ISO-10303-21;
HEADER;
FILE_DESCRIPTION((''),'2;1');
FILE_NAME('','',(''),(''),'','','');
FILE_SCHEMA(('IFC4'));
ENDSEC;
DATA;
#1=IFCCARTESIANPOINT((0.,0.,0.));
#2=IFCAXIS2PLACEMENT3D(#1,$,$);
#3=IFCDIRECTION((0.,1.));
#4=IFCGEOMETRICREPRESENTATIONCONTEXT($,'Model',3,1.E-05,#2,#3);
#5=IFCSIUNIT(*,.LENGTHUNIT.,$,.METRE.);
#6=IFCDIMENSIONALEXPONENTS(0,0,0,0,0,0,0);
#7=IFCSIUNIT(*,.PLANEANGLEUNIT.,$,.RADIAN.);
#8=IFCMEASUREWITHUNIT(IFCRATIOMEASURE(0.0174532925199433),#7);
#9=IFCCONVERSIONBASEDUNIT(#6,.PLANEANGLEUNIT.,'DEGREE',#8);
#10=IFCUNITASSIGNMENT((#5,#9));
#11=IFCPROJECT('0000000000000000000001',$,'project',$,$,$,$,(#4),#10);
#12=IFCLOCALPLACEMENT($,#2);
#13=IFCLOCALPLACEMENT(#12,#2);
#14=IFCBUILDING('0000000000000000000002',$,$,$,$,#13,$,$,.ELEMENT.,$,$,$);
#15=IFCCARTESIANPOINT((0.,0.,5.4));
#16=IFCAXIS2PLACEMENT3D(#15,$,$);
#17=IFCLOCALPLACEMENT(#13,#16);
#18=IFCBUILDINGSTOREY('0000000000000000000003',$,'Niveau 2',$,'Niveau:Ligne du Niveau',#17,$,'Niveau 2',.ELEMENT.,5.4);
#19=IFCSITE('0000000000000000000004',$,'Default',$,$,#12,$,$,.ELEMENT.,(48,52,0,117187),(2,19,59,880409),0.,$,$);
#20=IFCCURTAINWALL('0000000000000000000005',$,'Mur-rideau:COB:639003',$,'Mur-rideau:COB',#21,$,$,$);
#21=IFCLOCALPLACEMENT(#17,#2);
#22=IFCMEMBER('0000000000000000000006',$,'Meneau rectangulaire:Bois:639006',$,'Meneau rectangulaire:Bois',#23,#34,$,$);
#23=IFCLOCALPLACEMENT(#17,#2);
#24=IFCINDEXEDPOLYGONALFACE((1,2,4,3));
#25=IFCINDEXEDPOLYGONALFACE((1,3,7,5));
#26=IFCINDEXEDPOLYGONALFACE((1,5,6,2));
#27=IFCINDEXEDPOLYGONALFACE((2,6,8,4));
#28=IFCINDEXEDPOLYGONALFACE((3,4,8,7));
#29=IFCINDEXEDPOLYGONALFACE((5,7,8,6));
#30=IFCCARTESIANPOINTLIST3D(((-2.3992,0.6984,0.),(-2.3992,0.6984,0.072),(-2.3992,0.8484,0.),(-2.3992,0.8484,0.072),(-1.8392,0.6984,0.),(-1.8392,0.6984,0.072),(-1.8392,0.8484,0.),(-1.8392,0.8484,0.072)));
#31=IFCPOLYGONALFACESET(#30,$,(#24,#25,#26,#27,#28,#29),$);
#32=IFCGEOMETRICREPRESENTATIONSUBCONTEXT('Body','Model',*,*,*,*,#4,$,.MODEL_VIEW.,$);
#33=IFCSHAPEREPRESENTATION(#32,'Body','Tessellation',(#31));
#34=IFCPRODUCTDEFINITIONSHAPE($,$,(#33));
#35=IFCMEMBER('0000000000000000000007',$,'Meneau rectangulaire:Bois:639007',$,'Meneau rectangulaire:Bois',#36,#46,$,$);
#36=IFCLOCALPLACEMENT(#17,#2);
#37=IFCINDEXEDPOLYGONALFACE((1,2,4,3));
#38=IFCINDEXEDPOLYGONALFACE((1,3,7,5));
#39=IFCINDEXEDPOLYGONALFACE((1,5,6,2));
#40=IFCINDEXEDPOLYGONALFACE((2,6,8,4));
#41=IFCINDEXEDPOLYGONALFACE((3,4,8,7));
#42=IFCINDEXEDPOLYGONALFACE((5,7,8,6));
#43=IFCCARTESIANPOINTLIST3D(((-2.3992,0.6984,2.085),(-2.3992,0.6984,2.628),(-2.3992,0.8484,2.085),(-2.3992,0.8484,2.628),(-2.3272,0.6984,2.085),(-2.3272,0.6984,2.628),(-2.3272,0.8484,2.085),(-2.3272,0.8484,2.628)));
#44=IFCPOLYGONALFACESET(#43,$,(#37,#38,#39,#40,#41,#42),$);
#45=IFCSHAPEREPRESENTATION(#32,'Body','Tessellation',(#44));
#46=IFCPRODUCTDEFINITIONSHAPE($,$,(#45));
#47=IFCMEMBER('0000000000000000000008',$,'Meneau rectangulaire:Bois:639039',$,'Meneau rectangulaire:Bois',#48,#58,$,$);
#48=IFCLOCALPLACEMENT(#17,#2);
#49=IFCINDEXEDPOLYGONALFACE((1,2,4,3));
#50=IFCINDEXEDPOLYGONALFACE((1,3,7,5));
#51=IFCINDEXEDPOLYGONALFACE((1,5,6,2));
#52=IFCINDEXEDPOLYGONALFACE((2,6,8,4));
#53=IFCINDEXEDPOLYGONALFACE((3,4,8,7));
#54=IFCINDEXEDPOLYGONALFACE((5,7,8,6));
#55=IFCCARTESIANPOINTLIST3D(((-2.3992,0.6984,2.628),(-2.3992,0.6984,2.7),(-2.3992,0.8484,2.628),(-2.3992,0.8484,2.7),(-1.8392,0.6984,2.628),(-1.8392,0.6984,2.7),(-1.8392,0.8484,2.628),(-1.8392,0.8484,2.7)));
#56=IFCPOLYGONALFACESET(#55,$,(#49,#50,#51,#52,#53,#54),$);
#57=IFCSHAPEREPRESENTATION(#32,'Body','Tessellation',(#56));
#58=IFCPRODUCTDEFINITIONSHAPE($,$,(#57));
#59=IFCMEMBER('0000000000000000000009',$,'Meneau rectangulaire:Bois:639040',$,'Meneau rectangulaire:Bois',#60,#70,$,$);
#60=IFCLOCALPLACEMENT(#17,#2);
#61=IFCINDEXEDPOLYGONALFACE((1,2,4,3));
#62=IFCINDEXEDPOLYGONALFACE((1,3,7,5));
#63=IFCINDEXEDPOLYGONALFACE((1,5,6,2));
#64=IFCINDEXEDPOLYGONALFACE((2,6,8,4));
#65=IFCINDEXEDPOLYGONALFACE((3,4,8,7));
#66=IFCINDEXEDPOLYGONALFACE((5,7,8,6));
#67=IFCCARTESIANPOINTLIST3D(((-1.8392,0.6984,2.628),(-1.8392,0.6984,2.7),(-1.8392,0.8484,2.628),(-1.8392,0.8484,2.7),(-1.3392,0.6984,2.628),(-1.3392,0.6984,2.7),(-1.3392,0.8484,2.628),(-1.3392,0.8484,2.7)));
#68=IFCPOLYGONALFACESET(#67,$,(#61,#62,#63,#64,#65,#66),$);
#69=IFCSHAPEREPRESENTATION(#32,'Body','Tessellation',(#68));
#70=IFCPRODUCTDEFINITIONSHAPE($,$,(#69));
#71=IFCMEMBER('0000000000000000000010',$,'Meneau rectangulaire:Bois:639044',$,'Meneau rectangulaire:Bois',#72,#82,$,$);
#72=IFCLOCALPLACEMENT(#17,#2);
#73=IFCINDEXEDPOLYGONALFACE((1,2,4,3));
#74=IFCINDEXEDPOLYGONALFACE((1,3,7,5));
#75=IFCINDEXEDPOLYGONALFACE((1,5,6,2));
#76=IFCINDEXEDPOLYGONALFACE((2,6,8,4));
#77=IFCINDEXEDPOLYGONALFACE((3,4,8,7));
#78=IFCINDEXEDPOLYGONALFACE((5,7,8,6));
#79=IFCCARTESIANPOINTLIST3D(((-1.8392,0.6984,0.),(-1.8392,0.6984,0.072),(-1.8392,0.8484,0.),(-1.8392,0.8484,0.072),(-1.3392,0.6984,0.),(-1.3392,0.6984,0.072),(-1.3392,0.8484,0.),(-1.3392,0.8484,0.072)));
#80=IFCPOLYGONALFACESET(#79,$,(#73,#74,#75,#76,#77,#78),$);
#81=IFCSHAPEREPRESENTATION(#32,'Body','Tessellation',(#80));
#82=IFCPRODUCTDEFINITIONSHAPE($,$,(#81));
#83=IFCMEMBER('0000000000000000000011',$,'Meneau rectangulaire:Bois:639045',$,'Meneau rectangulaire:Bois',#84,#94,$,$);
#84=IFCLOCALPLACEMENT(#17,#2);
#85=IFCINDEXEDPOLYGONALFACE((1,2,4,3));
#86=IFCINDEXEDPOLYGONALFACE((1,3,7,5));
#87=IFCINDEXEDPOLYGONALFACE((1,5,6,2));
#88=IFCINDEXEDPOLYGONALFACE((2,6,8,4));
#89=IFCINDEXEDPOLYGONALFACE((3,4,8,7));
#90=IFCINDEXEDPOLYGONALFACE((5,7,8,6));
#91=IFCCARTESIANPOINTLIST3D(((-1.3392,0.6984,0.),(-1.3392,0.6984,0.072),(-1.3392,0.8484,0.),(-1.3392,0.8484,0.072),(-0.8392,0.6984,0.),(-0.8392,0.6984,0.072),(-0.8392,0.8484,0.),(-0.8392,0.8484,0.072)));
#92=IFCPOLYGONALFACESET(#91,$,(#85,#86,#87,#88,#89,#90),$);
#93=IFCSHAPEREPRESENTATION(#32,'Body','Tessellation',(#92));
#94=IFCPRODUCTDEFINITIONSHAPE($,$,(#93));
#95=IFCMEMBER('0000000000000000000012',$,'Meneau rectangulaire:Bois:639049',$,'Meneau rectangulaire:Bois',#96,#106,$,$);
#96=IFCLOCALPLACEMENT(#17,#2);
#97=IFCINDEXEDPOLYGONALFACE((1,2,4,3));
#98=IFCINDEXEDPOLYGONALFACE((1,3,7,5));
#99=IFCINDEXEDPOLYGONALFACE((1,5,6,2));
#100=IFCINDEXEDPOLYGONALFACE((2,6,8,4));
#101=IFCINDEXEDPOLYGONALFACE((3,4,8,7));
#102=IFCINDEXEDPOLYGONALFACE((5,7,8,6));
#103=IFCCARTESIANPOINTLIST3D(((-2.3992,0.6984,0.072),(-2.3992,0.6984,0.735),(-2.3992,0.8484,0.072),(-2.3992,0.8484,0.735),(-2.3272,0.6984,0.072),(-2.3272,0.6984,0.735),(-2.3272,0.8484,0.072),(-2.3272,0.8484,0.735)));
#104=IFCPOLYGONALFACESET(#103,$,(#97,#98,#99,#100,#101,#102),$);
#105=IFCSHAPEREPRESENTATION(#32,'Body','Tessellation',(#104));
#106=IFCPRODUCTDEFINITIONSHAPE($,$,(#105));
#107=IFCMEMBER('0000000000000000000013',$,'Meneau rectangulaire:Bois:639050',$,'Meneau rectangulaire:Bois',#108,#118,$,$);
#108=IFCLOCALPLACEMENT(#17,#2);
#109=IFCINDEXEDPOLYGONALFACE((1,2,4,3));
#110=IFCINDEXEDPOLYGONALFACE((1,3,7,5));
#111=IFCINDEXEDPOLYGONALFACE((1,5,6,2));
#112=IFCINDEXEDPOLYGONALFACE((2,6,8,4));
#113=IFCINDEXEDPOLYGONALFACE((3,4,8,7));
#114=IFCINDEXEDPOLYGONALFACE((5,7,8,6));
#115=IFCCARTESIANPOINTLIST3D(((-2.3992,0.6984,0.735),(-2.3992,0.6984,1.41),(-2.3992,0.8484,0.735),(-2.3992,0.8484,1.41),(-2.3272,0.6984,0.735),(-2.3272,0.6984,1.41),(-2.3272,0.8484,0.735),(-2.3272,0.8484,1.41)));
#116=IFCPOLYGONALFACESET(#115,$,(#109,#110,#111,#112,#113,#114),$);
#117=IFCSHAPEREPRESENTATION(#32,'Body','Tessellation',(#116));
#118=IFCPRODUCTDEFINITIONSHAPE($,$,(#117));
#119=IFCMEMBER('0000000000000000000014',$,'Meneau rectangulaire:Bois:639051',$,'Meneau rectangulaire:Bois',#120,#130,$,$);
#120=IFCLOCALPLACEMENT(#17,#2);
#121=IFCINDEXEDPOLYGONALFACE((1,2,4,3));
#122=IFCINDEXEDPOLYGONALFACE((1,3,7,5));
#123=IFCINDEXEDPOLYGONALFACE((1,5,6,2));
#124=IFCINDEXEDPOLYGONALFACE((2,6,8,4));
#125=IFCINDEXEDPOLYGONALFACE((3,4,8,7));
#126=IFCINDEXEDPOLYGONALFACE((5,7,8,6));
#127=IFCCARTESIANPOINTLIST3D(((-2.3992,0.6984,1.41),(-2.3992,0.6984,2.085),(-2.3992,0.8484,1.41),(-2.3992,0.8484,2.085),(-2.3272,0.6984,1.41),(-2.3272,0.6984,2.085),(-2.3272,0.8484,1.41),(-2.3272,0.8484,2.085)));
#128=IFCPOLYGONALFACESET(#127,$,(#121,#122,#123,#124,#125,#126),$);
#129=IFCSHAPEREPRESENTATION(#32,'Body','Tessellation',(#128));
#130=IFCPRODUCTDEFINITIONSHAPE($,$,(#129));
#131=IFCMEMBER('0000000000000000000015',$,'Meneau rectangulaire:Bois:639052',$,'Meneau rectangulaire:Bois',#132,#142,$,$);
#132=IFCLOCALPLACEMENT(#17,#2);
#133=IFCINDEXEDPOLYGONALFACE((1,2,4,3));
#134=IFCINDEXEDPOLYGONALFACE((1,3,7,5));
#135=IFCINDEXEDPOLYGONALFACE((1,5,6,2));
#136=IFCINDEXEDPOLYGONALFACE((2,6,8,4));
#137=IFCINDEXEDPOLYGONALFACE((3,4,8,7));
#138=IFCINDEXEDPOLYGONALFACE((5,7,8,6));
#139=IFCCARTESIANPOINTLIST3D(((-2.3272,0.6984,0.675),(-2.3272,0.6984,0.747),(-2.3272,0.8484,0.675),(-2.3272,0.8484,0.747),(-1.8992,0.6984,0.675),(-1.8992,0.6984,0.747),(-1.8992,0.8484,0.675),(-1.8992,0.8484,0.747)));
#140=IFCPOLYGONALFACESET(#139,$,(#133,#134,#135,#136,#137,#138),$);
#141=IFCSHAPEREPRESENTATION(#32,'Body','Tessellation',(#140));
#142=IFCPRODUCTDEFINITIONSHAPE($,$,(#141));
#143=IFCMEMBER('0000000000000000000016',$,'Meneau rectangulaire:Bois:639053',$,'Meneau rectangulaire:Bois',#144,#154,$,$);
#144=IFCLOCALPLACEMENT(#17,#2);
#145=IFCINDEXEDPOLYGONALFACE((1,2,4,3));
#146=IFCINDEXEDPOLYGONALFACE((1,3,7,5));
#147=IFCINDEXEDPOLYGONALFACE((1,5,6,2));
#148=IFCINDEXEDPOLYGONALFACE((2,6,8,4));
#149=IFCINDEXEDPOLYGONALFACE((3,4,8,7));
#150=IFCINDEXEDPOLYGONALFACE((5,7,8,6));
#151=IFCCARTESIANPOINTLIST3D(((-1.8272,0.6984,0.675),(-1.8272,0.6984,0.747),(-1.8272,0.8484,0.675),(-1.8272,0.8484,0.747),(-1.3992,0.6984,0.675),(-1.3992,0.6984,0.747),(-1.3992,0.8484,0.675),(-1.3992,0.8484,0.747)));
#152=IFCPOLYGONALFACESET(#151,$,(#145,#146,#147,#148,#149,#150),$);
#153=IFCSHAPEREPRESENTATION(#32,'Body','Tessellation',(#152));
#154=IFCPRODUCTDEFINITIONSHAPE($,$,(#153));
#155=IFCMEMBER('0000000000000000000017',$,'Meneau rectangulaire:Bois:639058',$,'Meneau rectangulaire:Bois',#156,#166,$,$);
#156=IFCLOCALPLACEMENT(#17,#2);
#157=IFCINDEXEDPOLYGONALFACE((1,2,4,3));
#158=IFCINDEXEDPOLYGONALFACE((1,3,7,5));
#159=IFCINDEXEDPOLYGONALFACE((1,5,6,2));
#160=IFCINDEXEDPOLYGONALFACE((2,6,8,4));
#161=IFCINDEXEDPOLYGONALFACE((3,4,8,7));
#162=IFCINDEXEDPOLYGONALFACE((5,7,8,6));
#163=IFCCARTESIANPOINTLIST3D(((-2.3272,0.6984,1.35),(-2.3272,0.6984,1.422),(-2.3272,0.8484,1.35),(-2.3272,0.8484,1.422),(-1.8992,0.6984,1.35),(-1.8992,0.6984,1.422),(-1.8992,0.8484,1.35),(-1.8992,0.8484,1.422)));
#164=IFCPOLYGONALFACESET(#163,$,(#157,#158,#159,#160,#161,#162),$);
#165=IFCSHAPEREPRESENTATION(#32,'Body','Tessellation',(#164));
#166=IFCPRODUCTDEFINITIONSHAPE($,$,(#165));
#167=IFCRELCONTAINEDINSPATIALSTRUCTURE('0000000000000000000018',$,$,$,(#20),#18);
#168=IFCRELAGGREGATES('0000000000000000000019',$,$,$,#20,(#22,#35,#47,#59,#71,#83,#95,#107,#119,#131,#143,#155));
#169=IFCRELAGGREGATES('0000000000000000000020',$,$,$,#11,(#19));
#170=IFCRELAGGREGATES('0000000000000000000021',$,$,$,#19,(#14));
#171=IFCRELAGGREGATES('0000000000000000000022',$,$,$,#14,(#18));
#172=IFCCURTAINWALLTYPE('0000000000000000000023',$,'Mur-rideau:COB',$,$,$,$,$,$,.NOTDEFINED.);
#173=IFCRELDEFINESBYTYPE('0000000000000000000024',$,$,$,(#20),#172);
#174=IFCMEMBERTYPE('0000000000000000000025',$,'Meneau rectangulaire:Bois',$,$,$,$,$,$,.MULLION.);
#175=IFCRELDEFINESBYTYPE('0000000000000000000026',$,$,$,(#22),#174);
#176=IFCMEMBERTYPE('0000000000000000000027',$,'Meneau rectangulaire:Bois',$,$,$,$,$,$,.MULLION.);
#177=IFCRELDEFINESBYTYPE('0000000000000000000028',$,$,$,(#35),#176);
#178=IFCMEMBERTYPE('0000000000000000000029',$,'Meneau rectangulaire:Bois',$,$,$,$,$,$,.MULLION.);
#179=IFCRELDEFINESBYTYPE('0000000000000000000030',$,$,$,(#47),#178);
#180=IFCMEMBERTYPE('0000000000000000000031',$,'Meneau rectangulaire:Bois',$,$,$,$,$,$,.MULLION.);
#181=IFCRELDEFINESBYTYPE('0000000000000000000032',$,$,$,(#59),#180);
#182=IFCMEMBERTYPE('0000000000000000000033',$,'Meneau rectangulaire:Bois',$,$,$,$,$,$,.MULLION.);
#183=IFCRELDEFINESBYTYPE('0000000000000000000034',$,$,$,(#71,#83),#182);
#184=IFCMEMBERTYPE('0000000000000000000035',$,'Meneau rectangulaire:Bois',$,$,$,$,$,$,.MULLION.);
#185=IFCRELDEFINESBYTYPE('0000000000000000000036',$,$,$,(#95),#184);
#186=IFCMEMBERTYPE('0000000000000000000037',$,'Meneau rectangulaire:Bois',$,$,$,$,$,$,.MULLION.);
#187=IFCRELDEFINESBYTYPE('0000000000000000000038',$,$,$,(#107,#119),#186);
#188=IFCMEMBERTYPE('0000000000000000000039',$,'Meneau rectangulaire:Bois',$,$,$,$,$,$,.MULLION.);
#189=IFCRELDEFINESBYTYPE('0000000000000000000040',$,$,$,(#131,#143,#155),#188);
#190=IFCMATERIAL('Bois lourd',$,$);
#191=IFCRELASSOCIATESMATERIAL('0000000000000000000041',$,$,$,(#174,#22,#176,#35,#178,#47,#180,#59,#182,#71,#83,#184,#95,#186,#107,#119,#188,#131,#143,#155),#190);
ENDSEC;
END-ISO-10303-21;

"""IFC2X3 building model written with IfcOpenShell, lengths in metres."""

from ifc_helpers import new_model, entity, si_unit, converted_unit, direction, frame, origin, origin_2d_with_axis, place, context, subcontext, project, spatial, rectangle, extrude, source, transform, mapped, material, type_object, type_shapes, element, aggregate, save


model = new_model("IFC2X3")

# Units and contexts
model_context = context("Model", 3, precision=1e-05, world=origin(), true_north=direction((0.0, 1.0)))
body_context = subcontext(model_context, "Body", "Model", "MODEL_VIEW")
ifc_project = project(units=[si_unit("LENGTHUNIT", "METRE"), converted_unit("PLANEANGLEUNIT", "DEGREE", entity("IfcRatioMeasure", 0.0174532925199433), si_unit("PLANEANGLEUNIT", "RADIAN"), dimensions=[0, 0, 0, 0, 0, 0, 0])], contexts=[model_context])

# Site, building, storey
site_placement = place(None, origin())
site = spatial("IfcSite", under=ifc_project, at=site_placement, Name="Default", CompositionType="ELEMENT", RefLatitude=(48, 52, 0, 117187), RefLongitude=(2, 19, 59, 880409), RefElevation=0.0)
building_placement = place(site_placement, origin())
building = spatial("IfcBuilding", under=site, at=building_placement, CompositionType="ELEMENT")
storey_placement = place(building_placement, frame((0.0, 0.0, 5.4)))
storey = spatial("IfcBuildingStorey", under=building, at=storey_placement, Name="Niveau 2", ObjectType="Niveau:Ligne du Niveau", LongName="Niveau 2", CompositionType="ELEMENT", Elevation=5.4)

# Curtain wall, members
curtain_wall_type_1 = type_object("IfcCurtainWallType", Name="Mur-rideau:COB", PredefinedType="NOTDEFINED")
curtain_wall_1_placement = place(storey_placement, frame((0.0, 0.0, -5.4)))
curtain_wall_1 = element("IfcCurtainWall", 1, at=curtain_wall_1_placement, inside=storey, type_object=curtain_wall_type_1, Name="Mur-rideau:COB:639003", ObjectType="Mur-rideau:COB")
ifc_material_1 = material(Name="Bois lourd")
member_type_1 = type_object("IfcMemberType", Name="Meneau rectangulaire:Bois", PredefinedType="MULLION", material=ifc_material_1)
shared_shape_1 = source(origin(), body_context, "Body", "SweptSolid", [
    extrude(rectangle(XDim=0.15, YDim=0.072, at=origin_2d_with_axis()), frame((-0.036, 0.0, -0.56), z_axis=(0.0, 0.0, 1.0), x_axis=(0.0, -1.0, 0.0)), (0.0, 0.0, 1.0), 0.56),
])
type_shapes(member_type_1, [shared_shape_1])
member_1_placement = place(storey_placement, frame((-2.3992, 0.7734, 0.0), z_axis=(-1.0, 0.0, 0.0), x_axis=(0.0, 0.0, -1.0)))
member_1 = element("IfcMember", 2, at=member_1_placement, type_object=member_type_1, material=ifc_material_1, Name="Meneau rectangulaire:Bois:639006", ObjectType="Meneau rectangulaire:Bois", context=body_context, shape_type="MappedRepresentation", body=[
    mapped(shared_shape_1, transform((0.0, 0.0, 0.0), scale=1.0)),
])
member_type_2 = type_object("IfcMemberType", Name="Meneau rectangulaire:Bois", PredefinedType="MULLION", material=ifc_material_1)
shared_shape_2 = source(origin(), body_context, "Body", "SweptSolid", [
    extrude(rectangle(XDim=0.15, YDim=0.072, at=origin_2d_with_axis()), frame((-0.036, 0.0, -0.543), z_axis=(0.0, 0.0, 1.0), x_axis=(0.0, -1.0, 0.0)), (0.0, 0.0, 1.0), 0.543),
])
type_shapes(member_type_2, [shared_shape_2])
member_2_placement = place(storey_placement, frame((-2.3992, 0.7734, 2.628), z_axis=(0.0, 0.0, 1.0), x_axis=(-1.0, 0.0, 0.0)))
member_2 = element("IfcMember", 3, at=member_2_placement, type_object=member_type_2, material=ifc_material_1, Name="Meneau rectangulaire:Bois:639007", ObjectType="Meneau rectangulaire:Bois", context=body_context, shape_type="MappedRepresentation", body=[
    mapped(shared_shape_2, transform((0.0, 0.0, 0.0), scale=1.0)),
])
member_type_3 = type_object("IfcMemberType", Name="Meneau rectangulaire:Bois", PredefinedType="MULLION", material=ifc_material_1)
shared_shape_3 = source(origin(), body_context, "Body", "SweptSolid", [
    extrude(rectangle(XDim=0.15, YDim=0.072, at=origin_2d_with_axis()), frame((-0.036, 0.0, -0.56), z_axis=(0.0, 0.0, 1.0), x_axis=(0.0, -1.0, 0.0)), (0.0, 0.0, 1.0), 0.56),
])
type_shapes(member_type_3, [shared_shape_3])
member_3_placement = place(storey_placement, frame((-1.8392, 0.7734, 2.7), z_axis=(1.0, 0.0, 0.0), x_axis=(0.0, 0.0, 1.0)))
member_3 = element("IfcMember", 4, at=member_3_placement, type_object=member_type_3, material=ifc_material_1, Name="Meneau rectangulaire:Bois:639039", ObjectType="Meneau rectangulaire:Bois", context=body_context, shape_type="MappedRepresentation", body=[
    mapped(shared_shape_3, transform((0.0, 0.0, 0.0), scale=1.0)),
])
member_type_4 = type_object("IfcMemberType", Name="Meneau rectangulaire:Bois", PredefinedType="MULLION", material=ifc_material_1)
shared_shape_4 = source(origin(), body_context, "Body", "SweptSolid", [
    extrude(rectangle(XDim=0.15, YDim=0.072, at=origin_2d_with_axis()), frame((-0.036, 0.0, -0.5), z_axis=(0.0, 0.0, 1.0), x_axis=(0.0, -1.0, 0.0)), (0.0, 0.0, 1.0), 0.5),
])
type_shapes(member_type_4, [shared_shape_4])
member_4_placement = place(storey_placement, frame((-1.3392, 0.7734, 2.7), z_axis=(1.0, 0.0, 0.0), x_axis=(0.0, 0.0, 1.0)))
member_4 = element("IfcMember", 5, at=member_4_placement, type_object=member_type_4, material=ifc_material_1, Name="Meneau rectangulaire:Bois:639040", ObjectType="Meneau rectangulaire:Bois", context=body_context, shape_type="MappedRepresentation", body=[
    mapped(shared_shape_4, transform((0.0, 0.0, 0.0), scale=1.0)),
])
member_type_5 = type_object("IfcMemberType", Name="Meneau rectangulaire:Bois", PredefinedType="MULLION", material=ifc_material_1)
shared_shape_5 = source(origin(), body_context, "Body", "SweptSolid", [
    extrude(rectangle(XDim=0.15, YDim=0.072, at=origin_2d_with_axis()), frame((-0.036, 0.0, -0.5), z_axis=(0.0, 0.0, 1.0), x_axis=(0.0, -1.0, 0.0)), (0.0, 0.0, 1.0), 0.5),
])
type_shapes(member_type_5, [shared_shape_5])
member_5_placement = place(storey_placement, frame((-1.8392, 0.7734, 0.0), z_axis=(-1.0, 0.0, 0.0), x_axis=(0.0, 0.0, -1.0)))
member_5 = element("IfcMember", 6, at=member_5_placement, type_object=member_type_5, material=ifc_material_1, Name="Meneau rectangulaire:Bois:639044", ObjectType="Meneau rectangulaire:Bois", context=body_context, shape_type="MappedRepresentation", body=[
    mapped(shared_shape_5, transform((0.0, 0.0, 0.0), scale=1.0)),
])
member_6_placement = place(storey_placement, frame((-1.3392, 0.7734, 0.0), z_axis=(-1.0, 0.0, 0.0), x_axis=(0.0, 0.0, -1.0)))
member_6 = element("IfcMember", 7, at=member_6_placement, type_object=member_type_5, material=ifc_material_1, Name="Meneau rectangulaire:Bois:639045", ObjectType="Meneau rectangulaire:Bois", context=body_context, shape_type="MappedRepresentation", body=[
    mapped(shared_shape_5, transform((0.0, 0.0, 0.0), scale=1.0)),
])
member_type_6 = type_object("IfcMemberType", Name="Meneau rectangulaire:Bois", PredefinedType="MULLION", material=ifc_material_1)
shared_shape_6 = source(origin(), body_context, "Body", "SweptSolid", [
    extrude(rectangle(XDim=0.15, YDim=0.072, at=origin_2d_with_axis()), frame((-0.036, 0.0, -0.663), z_axis=(0.0, 0.0, 1.0), x_axis=(0.0, -1.0, 0.0)), (0.0, 0.0, 1.0), 0.663),
])
type_shapes(member_type_6, [shared_shape_6])
member_7_placement = place(storey_placement, frame((-2.3992, 0.7734, 0.735), z_axis=(0.0, 0.0, 1.0), x_axis=(-1.0, 0.0, 0.0)))
member_7 = element("IfcMember", 8, at=member_7_placement, type_object=member_type_6, material=ifc_material_1, Name="Meneau rectangulaire:Bois:639049", ObjectType="Meneau rectangulaire:Bois", context=body_context, shape_type="MappedRepresentation", body=[
    mapped(shared_shape_6, transform((0.0, 0.0, 0.0), scale=1.0)),
])
member_type_7 = type_object("IfcMemberType", Name="Meneau rectangulaire:Bois", PredefinedType="MULLION", material=ifc_material_1)
shared_shape_7 = source(origin(), body_context, "Body", "SweptSolid", [
    extrude(rectangle(XDim=0.15, YDim=0.072, at=origin_2d_with_axis()), frame((-0.036, 0.0, -0.675), z_axis=(0.0, 0.0, 1.0), x_axis=(0.0, -1.0, 0.0)), (0.0, 0.0, 1.0), 0.675),
])
type_shapes(member_type_7, [shared_shape_7])
member_8_placement = place(storey_placement, frame((-2.3992, 0.7734, 1.41), z_axis=(0.0, 0.0, 1.0), x_axis=(-1.0, 0.0, 0.0)))
member_8 = element("IfcMember", 9, at=member_8_placement, type_object=member_type_7, material=ifc_material_1, Name="Meneau rectangulaire:Bois:639050", ObjectType="Meneau rectangulaire:Bois", context=body_context, shape_type="MappedRepresentation", body=[
    mapped(shared_shape_7, transform((0.0, 0.0, 0.0), scale=1.0)),
])
member_9_placement = place(storey_placement, frame((-2.3992, 0.7734, 2.085), z_axis=(0.0, 0.0, 1.0), x_axis=(-1.0, 0.0, 0.0)))
member_9 = element("IfcMember", 10, at=member_9_placement, type_object=member_type_7, material=ifc_material_1, Name="Meneau rectangulaire:Bois:639051", ObjectType="Meneau rectangulaire:Bois", context=body_context, shape_type="MappedRepresentation", body=[
    mapped(shared_shape_7, transform((0.0, 0.0, 0.0), scale=1.0)),
])
member_type_8 = type_object("IfcMemberType", Name="Meneau rectangulaire:Bois", PredefinedType="MULLION", material=ifc_material_1)
shared_shape_8 = source(origin(), body_context, "Body", "SweptSolid", [
    extrude(rectangle(XDim=0.15, YDim=0.072, at=origin_2d_with_axis()), frame((-0.024, 0.0, -0.428), z_axis=(0.0, 0.0, 1.0), x_axis=(0.0, -1.0, 0.0)), (0.0, 0.0, 1.0), 0.428),
])
type_shapes(member_type_8, [shared_shape_8])
member_10_placement = place(storey_placement, frame((-1.8992, 0.7734, 0.735), z_axis=(1.0, 0.0, 0.0), x_axis=(0.0, 0.0, 1.0)))
member_10 = element("IfcMember", 11, at=member_10_placement, type_object=member_type_8, material=ifc_material_1, Name="Meneau rectangulaire:Bois:639052", ObjectType="Meneau rectangulaire:Bois", context=body_context, shape_type="MappedRepresentation", body=[
    mapped(shared_shape_8, transform((0.0, 0.0, 0.0), scale=1.0)),
])
member_11_placement = place(storey_placement, frame((-1.3992, 0.7734, 0.735), z_axis=(1.0, 0.0, 0.0), x_axis=(0.0, 0.0, 1.0)))
member_11 = element("IfcMember", 12, at=member_11_placement, type_object=member_type_8, material=ifc_material_1, Name="Meneau rectangulaire:Bois:639053", ObjectType="Meneau rectangulaire:Bois", context=body_context, shape_type="MappedRepresentation", body=[
    mapped(shared_shape_8, transform((0.0, 0.0, 0.0), scale=1.0)),
])
member_12_placement = place(storey_placement, frame((-1.8992, 0.7734, 1.41), z_axis=(1.0, 0.0, 0.0), x_axis=(0.0, 0.0, 1.0)))
member_12 = element("IfcMember", 13, at=member_12_placement, type_object=member_type_8, material=ifc_material_1, Name="Meneau rectangulaire:Bois:639058", ObjectType="Meneau rectangulaire:Bois", context=body_context, shape_type="MappedRepresentation", body=[
    mapped(shared_shape_8, transform((0.0, 0.0, 0.0), scale=1.0)),
])
aggregate(curtain_wall_1, [member_1, member_2, member_3, member_4, member_5, member_6, member_7, member_8, member_9, member_10, member_11, member_12])

save(model, "model.ifc")
